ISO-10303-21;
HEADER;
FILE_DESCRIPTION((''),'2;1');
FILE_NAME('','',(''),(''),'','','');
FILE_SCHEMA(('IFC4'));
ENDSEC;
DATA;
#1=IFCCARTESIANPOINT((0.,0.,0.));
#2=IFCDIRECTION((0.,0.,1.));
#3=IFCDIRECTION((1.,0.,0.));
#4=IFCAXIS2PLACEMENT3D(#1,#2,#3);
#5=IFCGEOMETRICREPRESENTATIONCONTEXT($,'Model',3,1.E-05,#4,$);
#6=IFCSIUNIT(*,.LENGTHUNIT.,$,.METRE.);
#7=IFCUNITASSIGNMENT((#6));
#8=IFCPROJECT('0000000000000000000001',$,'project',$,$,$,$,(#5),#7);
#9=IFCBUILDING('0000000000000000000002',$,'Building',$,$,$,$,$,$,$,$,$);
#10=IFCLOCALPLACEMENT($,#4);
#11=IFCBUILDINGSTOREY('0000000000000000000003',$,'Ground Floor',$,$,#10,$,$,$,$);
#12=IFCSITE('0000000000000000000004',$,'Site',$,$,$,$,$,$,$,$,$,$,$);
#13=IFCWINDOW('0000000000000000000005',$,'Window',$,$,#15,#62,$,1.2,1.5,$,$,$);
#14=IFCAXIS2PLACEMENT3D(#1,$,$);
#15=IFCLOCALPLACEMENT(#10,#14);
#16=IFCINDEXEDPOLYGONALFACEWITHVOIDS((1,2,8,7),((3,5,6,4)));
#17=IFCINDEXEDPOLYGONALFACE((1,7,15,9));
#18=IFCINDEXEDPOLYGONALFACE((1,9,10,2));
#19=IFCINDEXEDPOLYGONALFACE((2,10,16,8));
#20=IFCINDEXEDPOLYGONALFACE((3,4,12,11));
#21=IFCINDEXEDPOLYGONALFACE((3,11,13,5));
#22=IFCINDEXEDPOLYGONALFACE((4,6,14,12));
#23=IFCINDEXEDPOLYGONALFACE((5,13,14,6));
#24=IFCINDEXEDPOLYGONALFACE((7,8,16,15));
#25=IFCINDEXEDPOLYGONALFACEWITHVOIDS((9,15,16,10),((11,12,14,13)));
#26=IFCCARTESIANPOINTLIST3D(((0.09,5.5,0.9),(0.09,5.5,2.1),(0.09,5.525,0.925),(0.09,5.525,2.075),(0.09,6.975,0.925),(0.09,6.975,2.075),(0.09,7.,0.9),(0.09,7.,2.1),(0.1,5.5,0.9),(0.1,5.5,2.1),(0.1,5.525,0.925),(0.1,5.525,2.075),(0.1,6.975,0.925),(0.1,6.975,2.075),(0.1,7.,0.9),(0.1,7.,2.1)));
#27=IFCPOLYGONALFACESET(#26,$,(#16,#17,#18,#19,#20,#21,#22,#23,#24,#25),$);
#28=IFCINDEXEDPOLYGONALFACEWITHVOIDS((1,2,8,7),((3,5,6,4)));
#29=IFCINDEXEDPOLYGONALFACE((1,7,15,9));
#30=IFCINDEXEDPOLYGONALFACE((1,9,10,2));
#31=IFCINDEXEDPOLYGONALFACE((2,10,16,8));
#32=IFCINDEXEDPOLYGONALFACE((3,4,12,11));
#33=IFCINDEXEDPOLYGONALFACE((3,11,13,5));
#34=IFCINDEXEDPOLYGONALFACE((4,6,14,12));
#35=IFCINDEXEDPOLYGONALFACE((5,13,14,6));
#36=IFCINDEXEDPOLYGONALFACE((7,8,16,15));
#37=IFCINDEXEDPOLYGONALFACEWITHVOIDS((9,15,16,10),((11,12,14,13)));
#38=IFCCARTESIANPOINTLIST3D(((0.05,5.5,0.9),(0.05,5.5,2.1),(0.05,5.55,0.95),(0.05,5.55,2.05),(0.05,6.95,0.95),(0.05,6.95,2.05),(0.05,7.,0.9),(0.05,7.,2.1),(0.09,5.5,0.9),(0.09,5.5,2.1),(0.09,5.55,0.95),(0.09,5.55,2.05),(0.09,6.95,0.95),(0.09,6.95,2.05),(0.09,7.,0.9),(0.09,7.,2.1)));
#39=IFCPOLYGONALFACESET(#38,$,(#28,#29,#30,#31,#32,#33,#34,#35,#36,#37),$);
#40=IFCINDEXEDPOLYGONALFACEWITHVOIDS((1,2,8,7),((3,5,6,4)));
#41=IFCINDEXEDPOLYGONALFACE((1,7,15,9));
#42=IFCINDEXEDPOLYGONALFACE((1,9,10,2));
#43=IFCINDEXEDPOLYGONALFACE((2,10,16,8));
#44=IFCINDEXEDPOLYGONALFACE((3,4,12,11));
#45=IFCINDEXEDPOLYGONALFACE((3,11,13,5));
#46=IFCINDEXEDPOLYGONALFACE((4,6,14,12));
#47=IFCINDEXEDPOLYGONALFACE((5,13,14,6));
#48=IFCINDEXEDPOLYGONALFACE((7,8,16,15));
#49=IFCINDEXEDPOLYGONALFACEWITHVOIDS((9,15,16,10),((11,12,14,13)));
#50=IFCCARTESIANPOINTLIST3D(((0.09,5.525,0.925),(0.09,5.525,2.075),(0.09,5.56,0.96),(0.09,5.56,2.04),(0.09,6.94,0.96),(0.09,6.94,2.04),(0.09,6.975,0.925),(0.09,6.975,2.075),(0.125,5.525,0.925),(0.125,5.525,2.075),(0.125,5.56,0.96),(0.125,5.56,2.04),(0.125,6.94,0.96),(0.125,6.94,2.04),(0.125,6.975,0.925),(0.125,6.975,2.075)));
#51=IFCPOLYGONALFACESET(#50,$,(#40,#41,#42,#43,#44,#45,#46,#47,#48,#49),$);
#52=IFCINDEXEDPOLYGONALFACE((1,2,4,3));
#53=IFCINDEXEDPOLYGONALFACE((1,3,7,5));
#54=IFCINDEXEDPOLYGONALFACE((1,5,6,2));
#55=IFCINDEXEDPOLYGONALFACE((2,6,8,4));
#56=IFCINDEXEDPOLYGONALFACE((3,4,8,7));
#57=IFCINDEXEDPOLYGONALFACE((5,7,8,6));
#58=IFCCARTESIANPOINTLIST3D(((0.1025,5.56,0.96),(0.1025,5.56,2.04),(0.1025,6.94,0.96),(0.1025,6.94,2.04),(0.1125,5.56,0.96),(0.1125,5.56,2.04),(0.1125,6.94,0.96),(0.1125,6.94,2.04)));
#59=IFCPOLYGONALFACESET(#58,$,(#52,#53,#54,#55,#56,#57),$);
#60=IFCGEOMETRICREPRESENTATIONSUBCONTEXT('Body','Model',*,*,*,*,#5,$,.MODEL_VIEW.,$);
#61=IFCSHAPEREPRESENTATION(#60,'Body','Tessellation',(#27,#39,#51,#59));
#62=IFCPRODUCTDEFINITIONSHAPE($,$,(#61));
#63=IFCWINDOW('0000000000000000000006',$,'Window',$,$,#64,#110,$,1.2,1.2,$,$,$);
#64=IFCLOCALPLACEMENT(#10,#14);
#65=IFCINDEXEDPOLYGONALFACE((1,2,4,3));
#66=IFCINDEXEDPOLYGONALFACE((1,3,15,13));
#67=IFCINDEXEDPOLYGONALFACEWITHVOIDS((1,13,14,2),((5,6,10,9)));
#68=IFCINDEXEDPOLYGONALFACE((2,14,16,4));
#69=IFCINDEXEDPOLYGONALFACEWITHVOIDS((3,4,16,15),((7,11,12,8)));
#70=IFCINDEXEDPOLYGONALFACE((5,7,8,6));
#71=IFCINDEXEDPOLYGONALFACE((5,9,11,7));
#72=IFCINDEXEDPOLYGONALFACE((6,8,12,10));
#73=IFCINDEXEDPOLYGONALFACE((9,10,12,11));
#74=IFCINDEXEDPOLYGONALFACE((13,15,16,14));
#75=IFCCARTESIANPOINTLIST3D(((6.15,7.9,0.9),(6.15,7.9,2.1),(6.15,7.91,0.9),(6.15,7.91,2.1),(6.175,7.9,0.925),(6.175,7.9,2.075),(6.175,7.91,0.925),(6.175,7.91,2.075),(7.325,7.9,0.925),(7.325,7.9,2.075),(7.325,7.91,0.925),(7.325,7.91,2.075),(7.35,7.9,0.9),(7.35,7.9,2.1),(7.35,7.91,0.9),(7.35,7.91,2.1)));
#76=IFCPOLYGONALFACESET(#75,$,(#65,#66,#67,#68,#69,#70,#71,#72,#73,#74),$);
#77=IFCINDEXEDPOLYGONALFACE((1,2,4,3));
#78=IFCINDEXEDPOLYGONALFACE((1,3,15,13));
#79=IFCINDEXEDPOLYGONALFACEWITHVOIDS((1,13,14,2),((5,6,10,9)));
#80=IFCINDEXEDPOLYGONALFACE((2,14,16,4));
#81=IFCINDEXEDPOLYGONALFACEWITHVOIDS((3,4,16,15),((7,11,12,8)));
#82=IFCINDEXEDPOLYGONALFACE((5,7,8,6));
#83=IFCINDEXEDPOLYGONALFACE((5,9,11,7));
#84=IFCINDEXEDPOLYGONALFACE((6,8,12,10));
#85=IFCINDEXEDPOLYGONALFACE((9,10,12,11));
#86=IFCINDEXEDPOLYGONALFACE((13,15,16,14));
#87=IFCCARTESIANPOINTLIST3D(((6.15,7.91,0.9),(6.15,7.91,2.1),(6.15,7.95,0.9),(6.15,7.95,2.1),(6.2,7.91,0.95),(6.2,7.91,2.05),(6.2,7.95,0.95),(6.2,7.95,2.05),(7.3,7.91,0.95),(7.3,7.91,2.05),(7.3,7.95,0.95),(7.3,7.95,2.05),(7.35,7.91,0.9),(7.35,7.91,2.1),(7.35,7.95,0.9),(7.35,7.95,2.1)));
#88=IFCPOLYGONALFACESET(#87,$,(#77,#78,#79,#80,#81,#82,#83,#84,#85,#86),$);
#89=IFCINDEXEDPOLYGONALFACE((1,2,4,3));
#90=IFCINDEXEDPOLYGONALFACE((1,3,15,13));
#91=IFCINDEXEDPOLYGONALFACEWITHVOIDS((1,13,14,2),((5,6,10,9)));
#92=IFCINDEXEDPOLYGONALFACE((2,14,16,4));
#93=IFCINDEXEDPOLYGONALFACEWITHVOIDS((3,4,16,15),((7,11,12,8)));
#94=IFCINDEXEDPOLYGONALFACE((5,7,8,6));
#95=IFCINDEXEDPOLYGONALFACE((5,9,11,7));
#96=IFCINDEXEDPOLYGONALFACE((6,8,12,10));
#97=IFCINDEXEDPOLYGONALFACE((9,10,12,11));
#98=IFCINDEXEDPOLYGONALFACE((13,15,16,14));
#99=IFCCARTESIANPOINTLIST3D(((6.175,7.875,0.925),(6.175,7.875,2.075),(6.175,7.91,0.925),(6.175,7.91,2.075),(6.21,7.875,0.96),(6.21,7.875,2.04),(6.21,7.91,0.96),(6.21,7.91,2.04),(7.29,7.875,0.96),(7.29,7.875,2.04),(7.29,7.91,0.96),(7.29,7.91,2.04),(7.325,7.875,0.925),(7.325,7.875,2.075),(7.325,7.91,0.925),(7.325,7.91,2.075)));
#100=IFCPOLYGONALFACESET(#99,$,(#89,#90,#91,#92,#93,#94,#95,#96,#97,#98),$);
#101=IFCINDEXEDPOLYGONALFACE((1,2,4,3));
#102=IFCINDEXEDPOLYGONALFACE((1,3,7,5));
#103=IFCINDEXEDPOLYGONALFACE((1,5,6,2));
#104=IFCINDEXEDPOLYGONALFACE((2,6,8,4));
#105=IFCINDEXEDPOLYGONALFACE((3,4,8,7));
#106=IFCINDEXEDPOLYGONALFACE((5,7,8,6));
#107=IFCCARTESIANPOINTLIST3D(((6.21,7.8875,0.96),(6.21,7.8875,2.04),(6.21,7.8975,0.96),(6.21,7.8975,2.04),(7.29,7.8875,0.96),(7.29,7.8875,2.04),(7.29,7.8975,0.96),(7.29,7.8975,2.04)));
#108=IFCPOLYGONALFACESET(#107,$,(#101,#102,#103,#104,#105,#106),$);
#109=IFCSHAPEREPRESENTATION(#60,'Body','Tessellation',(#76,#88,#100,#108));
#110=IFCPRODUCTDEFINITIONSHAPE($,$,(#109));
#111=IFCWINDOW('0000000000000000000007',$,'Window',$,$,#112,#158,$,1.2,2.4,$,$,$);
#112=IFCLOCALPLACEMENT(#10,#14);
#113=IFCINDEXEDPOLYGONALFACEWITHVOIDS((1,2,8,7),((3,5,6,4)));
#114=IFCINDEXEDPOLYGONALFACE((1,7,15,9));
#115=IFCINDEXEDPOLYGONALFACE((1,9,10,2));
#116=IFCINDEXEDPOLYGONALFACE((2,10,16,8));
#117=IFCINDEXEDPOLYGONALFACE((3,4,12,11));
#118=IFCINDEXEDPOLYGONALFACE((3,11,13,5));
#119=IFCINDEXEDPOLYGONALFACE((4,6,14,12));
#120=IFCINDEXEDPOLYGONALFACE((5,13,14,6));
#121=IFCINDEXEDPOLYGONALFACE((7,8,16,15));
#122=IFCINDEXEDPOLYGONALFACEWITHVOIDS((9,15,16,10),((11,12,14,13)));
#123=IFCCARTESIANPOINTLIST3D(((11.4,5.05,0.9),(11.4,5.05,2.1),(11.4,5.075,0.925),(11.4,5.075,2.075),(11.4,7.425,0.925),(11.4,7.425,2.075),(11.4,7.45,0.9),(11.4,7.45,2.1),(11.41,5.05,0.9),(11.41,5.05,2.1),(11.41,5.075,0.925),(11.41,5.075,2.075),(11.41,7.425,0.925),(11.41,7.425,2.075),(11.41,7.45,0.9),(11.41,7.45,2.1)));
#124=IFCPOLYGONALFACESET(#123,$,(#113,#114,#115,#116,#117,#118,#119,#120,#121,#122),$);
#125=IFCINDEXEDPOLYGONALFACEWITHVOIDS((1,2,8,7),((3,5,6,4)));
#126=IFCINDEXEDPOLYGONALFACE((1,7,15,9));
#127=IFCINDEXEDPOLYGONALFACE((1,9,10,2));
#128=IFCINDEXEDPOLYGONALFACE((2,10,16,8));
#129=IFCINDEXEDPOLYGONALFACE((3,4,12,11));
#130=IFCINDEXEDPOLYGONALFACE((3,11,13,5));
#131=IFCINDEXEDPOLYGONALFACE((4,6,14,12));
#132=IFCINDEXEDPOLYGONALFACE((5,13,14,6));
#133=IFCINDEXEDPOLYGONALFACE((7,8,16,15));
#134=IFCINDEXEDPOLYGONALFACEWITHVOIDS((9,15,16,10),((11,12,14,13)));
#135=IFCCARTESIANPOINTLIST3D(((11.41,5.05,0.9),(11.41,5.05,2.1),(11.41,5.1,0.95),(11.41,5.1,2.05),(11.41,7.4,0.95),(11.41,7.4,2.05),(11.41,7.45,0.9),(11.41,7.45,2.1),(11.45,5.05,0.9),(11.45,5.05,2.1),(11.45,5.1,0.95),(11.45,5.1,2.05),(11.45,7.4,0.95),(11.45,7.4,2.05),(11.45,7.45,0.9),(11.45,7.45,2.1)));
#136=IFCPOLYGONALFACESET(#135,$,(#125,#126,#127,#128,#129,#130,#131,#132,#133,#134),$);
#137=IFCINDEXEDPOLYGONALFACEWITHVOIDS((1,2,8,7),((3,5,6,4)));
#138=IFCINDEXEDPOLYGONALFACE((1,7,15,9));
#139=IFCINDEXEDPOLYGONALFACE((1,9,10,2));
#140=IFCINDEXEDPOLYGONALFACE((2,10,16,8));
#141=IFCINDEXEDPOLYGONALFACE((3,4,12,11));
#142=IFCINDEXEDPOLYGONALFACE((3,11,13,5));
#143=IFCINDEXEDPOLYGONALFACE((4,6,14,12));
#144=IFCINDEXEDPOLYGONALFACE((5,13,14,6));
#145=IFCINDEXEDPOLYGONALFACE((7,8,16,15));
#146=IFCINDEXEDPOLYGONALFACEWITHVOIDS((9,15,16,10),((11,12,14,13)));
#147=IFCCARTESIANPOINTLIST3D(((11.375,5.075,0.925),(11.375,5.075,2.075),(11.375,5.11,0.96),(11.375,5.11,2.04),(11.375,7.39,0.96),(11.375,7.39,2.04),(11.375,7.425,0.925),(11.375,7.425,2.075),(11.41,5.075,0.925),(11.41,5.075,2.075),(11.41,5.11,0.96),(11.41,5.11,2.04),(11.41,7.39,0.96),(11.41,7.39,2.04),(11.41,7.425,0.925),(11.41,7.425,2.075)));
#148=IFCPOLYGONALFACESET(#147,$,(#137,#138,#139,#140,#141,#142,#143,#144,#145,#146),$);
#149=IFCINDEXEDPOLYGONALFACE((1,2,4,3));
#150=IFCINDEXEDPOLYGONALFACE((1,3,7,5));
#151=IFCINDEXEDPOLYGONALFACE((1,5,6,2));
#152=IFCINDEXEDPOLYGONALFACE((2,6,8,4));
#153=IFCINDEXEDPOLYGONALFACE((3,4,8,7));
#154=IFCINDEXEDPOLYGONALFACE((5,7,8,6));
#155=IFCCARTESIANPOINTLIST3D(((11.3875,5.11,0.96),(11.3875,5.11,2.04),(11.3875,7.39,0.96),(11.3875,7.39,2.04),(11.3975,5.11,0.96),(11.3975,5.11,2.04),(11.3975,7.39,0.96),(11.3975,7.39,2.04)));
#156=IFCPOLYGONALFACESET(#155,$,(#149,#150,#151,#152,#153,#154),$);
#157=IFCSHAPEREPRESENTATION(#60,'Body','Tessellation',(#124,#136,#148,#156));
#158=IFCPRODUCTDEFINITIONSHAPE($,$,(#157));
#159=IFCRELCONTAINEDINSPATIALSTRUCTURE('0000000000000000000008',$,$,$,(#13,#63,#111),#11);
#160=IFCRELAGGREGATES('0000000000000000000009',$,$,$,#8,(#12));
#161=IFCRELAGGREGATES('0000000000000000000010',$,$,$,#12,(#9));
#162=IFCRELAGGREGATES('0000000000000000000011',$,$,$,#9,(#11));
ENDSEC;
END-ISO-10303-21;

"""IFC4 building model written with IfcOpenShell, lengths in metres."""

from ifc_helpers import new_model, si_unit, frame, origin_with_axes, place, context, subcontext, project, spatial, line, indexed_curve, outline, extrude, element, save


model = new_model("IFC4")

# Units and contexts
model_context = context("Model", 3, precision=1e-05, world=origin_with_axes())
body_context = subcontext(model_context, "Body", "Model", "MODEL_VIEW")
ifc_project = project(units=[si_unit("LENGTHUNIT", "METRE")], contexts=[model_context])

# Site, building, storey
site = spatial("IfcSite", under=ifc_project, Name="Site")
building = spatial("IfcBuilding", under=site, Name="Building")
storey_placement = place(None, origin_with_axes())
storey = spatial("IfcBuildingStorey", under=building, at=storey_placement, Name="Ground Floor")

# Windows
for number, where, z_axis, x_axis, name in (
    (1, (0.0, 7.0, 0.9), (0.0, 0.0, 1.0), (0.0, -1.0, 0.0), "Window"),
):
    element("IfcWindow", number, at=place(storey_placement, frame(where, z_axis=z_axis, x_axis=x_axis)), inside=storey, Name=name, OverallHeight=1.2, OverallWidth=1.5, context=body_context, shape_type="SweptSolid", body=[
        extrude(outline(indexed_curve([(0.0, 0.0), (1.5, 0.0), (1.5, 1.2), (0.0, 1.2)], segments=[line(1, 2, 3, 4, 1)]), holes=[indexed_curve([(0.025, 0.025), (1.475, 0.025), (1.475, 1.175), (0.025, 1.175)], segments=[line(1, 2, 3, 4, 1)])]), frame((0.0, 0.09, 0.0), z_axis=(0.0, -1.0, 0.0), x_axis=(1.0, 0.0, 0.0)), (0.0, 0.0, -1.0), 0.01),
        extrude(outline(indexed_curve([(0.0, 0.0), (1.5, 0.0), (1.5, 1.2), (0.0, 1.2)], segments=[line(1, 2, 3, 4, 1)]), holes=[indexed_curve([(0.05, 0.05), (1.45, 0.05), (1.45, 1.15), (0.05, 1.15)], segments=[line(1, 2, 3, 4, 1)])]), frame((0.0, 0.05, 0.0), z_axis=(0.0, -1.0, 0.0), x_axis=(1.0, 0.0, 0.0)), (0.0, 0.0, -1.0), 0.04),
        extrude(outline(indexed_curve([(0.0, 0.0), (1.45, 0.0), (1.45, 1.15), (0.0, 1.15)], segments=[line(1, 2, 3, 4, 1)]), holes=[indexed_curve([(0.035, 0.035), (1.415, 0.035), (1.415, 1.115), (0.035, 1.115)], segments=[line(1, 2, 3, 4, 1)])]), frame((0.025, 0.09, 0.025), z_axis=(0.0, -1.0, 0.0), x_axis=(1.0, 0.0, 0.0)), (0.0, 0.0, -1.0), 0.035),
        extrude(outline(indexed_curve([(0.035, 0.035), (1.415, 0.035), (1.415, 1.115), (0.035, 1.115)], segments=[line(1, 2, 3, 4, 1)])), frame((0.025, 0.1025, 0.025), z_axis=(0.0, -1.0, 0.0), x_axis=(1.0, 0.0, 0.0)), (0.0, 0.0, -1.0), 0.01),
    ])
window_1_placement = place(storey_placement, frame((7.35, 8.0, 0.9), z_axis=(0.0, 0.0, 1.0), x_axis=(-1.0, 0.0, 0.0)))
element("IfcWindow", 2, at=window_1_placement, inside=storey, Name="Window", OverallHeight=1.2, OverallWidth=1.2, context=body_context, shape_type="SweptSolid", body=[
    extrude(outline(indexed_curve([(0.0, 0.0), (1.2, 0.0), (1.2, 1.2), (0.0, 1.2)], segments=[line(1, 2, 3, 4, 1)]), holes=[indexed_curve([(0.025, 0.025), (1.175, 0.025), (1.175, 1.175), (0.025, 1.175)], segments=[line(1, 2, 3, 4, 1)])]), frame((0.0, 0.09, 0.0), z_axis=(0.0, -1.0, 0.0), x_axis=(1.0, 0.0, 0.0)), (0.0, 0.0, -1.0), 0.01),
    extrude(outline(indexed_curve([(0.0, 0.0), (1.2, 0.0), (1.2, 1.2), (0.0, 1.2)], segments=[line(1, 2, 3, 4, 1)]), holes=[indexed_curve([(0.05, 0.05), (1.15, 0.05), (1.15, 1.15), (0.05, 1.15)], segments=[line(1, 2, 3, 4, 1)])]), frame((0.0, 0.05, 0.0), z_axis=(0.0, -1.0, 0.0), x_axis=(1.0, 0.0, 0.0)), (0.0, 0.0, -1.0), 0.04),
    extrude(outline(indexed_curve([(0.0, 0.0), (1.15, 0.0), (1.15, 1.15), (0.0, 1.15)], segments=[line(1, 2, 3, 4, 1)]), holes=[indexed_curve([(0.035, 0.035), (1.115, 0.035), (1.115, 1.115), (0.035, 1.115)], segments=[line(1, 2, 3, 4, 1)])]), frame((0.025, 0.09, 0.025), z_axis=(0.0, -1.0, 0.0), x_axis=(1.0, 0.0, 0.0)), (0.0, 0.0, -1.0), 0.035),
    extrude(outline(indexed_curve([(0.035, 0.035), (1.115, 0.035), (1.115, 1.115), (0.035, 1.115)], segments=[line(1, 2, 3, 4, 1)])), frame((0.025, 0.1025, 0.025), z_axis=(0.0, -1.0, 0.0), x_axis=(1.0, 0.0, 0.0)), (0.0, 0.0, -1.0), 0.01),
])
window_2_placement = place(storey_placement, frame((11.5, 5.05, 0.9), z_axis=(0.0, 0.0, 1.0), x_axis=(0.0, 1.0, 0.0)))
element("IfcWindow", 3, at=window_2_placement, inside=storey, Name="Window", OverallHeight=1.2, OverallWidth=2.4, context=body_context, shape_type="SweptSolid", body=[
    extrude(outline(indexed_curve([(0.0, 0.0), (2.4, 0.0), (2.4, 1.2), (0.0, 1.2)], segments=[line(1, 2, 3, 4, 1)]), holes=[indexed_curve([(0.025, 0.025), (2.375, 0.025), (2.375, 1.175), (0.025, 1.175)], segments=[line(1, 2, 3, 4, 1)])]), frame((0.0, 0.09, 0.0), z_axis=(0.0, -1.0, 0.0), x_axis=(1.0, 0.0, 0.0)), (0.0, 0.0, -1.0), 0.01),
    extrude(outline(indexed_curve([(0.0, 0.0), (2.4, 0.0), (2.4, 1.2), (0.0, 1.2)], segments=[line(1, 2, 3, 4, 1)]), holes=[indexed_curve([(0.05, 0.05), (2.35, 0.05), (2.35, 1.15), (0.05, 1.15)], segments=[line(1, 2, 3, 4, 1)])]), frame((0.0, 0.05, 0.0), z_axis=(0.0, -1.0, 0.0), x_axis=(1.0, 0.0, 0.0)), (0.0, 0.0, -1.0), 0.04),
    extrude(outline(indexed_curve([(0.0, 0.0), (2.35, 0.0), (2.35, 1.15), (0.0, 1.15)], segments=[line(1, 2, 3, 4, 1)]), holes=[indexed_curve([(0.035, 0.035), (2.315, 0.035), (2.315, 1.115), (0.035, 1.115)], segments=[line(1, 2, 3, 4, 1)])]), frame((0.025, 0.09, 0.025), z_axis=(0.0, -1.0, 0.0), x_axis=(1.0, 0.0, 0.0)), (0.0, 0.0, -1.0), 0.035),
    extrude(outline(indexed_curve([(0.035, 0.035), (2.315, 0.035), (2.315, 1.115), (0.035, 1.115)], segments=[line(1, 2, 3, 4, 1)])), frame((0.025, 0.1025, 0.025), z_axis=(0.0, -1.0, 0.0), x_axis=(1.0, 0.0, 0.0)), (0.0, 0.0, -1.0), 0.01),
])

save(model, "model.ifc")
